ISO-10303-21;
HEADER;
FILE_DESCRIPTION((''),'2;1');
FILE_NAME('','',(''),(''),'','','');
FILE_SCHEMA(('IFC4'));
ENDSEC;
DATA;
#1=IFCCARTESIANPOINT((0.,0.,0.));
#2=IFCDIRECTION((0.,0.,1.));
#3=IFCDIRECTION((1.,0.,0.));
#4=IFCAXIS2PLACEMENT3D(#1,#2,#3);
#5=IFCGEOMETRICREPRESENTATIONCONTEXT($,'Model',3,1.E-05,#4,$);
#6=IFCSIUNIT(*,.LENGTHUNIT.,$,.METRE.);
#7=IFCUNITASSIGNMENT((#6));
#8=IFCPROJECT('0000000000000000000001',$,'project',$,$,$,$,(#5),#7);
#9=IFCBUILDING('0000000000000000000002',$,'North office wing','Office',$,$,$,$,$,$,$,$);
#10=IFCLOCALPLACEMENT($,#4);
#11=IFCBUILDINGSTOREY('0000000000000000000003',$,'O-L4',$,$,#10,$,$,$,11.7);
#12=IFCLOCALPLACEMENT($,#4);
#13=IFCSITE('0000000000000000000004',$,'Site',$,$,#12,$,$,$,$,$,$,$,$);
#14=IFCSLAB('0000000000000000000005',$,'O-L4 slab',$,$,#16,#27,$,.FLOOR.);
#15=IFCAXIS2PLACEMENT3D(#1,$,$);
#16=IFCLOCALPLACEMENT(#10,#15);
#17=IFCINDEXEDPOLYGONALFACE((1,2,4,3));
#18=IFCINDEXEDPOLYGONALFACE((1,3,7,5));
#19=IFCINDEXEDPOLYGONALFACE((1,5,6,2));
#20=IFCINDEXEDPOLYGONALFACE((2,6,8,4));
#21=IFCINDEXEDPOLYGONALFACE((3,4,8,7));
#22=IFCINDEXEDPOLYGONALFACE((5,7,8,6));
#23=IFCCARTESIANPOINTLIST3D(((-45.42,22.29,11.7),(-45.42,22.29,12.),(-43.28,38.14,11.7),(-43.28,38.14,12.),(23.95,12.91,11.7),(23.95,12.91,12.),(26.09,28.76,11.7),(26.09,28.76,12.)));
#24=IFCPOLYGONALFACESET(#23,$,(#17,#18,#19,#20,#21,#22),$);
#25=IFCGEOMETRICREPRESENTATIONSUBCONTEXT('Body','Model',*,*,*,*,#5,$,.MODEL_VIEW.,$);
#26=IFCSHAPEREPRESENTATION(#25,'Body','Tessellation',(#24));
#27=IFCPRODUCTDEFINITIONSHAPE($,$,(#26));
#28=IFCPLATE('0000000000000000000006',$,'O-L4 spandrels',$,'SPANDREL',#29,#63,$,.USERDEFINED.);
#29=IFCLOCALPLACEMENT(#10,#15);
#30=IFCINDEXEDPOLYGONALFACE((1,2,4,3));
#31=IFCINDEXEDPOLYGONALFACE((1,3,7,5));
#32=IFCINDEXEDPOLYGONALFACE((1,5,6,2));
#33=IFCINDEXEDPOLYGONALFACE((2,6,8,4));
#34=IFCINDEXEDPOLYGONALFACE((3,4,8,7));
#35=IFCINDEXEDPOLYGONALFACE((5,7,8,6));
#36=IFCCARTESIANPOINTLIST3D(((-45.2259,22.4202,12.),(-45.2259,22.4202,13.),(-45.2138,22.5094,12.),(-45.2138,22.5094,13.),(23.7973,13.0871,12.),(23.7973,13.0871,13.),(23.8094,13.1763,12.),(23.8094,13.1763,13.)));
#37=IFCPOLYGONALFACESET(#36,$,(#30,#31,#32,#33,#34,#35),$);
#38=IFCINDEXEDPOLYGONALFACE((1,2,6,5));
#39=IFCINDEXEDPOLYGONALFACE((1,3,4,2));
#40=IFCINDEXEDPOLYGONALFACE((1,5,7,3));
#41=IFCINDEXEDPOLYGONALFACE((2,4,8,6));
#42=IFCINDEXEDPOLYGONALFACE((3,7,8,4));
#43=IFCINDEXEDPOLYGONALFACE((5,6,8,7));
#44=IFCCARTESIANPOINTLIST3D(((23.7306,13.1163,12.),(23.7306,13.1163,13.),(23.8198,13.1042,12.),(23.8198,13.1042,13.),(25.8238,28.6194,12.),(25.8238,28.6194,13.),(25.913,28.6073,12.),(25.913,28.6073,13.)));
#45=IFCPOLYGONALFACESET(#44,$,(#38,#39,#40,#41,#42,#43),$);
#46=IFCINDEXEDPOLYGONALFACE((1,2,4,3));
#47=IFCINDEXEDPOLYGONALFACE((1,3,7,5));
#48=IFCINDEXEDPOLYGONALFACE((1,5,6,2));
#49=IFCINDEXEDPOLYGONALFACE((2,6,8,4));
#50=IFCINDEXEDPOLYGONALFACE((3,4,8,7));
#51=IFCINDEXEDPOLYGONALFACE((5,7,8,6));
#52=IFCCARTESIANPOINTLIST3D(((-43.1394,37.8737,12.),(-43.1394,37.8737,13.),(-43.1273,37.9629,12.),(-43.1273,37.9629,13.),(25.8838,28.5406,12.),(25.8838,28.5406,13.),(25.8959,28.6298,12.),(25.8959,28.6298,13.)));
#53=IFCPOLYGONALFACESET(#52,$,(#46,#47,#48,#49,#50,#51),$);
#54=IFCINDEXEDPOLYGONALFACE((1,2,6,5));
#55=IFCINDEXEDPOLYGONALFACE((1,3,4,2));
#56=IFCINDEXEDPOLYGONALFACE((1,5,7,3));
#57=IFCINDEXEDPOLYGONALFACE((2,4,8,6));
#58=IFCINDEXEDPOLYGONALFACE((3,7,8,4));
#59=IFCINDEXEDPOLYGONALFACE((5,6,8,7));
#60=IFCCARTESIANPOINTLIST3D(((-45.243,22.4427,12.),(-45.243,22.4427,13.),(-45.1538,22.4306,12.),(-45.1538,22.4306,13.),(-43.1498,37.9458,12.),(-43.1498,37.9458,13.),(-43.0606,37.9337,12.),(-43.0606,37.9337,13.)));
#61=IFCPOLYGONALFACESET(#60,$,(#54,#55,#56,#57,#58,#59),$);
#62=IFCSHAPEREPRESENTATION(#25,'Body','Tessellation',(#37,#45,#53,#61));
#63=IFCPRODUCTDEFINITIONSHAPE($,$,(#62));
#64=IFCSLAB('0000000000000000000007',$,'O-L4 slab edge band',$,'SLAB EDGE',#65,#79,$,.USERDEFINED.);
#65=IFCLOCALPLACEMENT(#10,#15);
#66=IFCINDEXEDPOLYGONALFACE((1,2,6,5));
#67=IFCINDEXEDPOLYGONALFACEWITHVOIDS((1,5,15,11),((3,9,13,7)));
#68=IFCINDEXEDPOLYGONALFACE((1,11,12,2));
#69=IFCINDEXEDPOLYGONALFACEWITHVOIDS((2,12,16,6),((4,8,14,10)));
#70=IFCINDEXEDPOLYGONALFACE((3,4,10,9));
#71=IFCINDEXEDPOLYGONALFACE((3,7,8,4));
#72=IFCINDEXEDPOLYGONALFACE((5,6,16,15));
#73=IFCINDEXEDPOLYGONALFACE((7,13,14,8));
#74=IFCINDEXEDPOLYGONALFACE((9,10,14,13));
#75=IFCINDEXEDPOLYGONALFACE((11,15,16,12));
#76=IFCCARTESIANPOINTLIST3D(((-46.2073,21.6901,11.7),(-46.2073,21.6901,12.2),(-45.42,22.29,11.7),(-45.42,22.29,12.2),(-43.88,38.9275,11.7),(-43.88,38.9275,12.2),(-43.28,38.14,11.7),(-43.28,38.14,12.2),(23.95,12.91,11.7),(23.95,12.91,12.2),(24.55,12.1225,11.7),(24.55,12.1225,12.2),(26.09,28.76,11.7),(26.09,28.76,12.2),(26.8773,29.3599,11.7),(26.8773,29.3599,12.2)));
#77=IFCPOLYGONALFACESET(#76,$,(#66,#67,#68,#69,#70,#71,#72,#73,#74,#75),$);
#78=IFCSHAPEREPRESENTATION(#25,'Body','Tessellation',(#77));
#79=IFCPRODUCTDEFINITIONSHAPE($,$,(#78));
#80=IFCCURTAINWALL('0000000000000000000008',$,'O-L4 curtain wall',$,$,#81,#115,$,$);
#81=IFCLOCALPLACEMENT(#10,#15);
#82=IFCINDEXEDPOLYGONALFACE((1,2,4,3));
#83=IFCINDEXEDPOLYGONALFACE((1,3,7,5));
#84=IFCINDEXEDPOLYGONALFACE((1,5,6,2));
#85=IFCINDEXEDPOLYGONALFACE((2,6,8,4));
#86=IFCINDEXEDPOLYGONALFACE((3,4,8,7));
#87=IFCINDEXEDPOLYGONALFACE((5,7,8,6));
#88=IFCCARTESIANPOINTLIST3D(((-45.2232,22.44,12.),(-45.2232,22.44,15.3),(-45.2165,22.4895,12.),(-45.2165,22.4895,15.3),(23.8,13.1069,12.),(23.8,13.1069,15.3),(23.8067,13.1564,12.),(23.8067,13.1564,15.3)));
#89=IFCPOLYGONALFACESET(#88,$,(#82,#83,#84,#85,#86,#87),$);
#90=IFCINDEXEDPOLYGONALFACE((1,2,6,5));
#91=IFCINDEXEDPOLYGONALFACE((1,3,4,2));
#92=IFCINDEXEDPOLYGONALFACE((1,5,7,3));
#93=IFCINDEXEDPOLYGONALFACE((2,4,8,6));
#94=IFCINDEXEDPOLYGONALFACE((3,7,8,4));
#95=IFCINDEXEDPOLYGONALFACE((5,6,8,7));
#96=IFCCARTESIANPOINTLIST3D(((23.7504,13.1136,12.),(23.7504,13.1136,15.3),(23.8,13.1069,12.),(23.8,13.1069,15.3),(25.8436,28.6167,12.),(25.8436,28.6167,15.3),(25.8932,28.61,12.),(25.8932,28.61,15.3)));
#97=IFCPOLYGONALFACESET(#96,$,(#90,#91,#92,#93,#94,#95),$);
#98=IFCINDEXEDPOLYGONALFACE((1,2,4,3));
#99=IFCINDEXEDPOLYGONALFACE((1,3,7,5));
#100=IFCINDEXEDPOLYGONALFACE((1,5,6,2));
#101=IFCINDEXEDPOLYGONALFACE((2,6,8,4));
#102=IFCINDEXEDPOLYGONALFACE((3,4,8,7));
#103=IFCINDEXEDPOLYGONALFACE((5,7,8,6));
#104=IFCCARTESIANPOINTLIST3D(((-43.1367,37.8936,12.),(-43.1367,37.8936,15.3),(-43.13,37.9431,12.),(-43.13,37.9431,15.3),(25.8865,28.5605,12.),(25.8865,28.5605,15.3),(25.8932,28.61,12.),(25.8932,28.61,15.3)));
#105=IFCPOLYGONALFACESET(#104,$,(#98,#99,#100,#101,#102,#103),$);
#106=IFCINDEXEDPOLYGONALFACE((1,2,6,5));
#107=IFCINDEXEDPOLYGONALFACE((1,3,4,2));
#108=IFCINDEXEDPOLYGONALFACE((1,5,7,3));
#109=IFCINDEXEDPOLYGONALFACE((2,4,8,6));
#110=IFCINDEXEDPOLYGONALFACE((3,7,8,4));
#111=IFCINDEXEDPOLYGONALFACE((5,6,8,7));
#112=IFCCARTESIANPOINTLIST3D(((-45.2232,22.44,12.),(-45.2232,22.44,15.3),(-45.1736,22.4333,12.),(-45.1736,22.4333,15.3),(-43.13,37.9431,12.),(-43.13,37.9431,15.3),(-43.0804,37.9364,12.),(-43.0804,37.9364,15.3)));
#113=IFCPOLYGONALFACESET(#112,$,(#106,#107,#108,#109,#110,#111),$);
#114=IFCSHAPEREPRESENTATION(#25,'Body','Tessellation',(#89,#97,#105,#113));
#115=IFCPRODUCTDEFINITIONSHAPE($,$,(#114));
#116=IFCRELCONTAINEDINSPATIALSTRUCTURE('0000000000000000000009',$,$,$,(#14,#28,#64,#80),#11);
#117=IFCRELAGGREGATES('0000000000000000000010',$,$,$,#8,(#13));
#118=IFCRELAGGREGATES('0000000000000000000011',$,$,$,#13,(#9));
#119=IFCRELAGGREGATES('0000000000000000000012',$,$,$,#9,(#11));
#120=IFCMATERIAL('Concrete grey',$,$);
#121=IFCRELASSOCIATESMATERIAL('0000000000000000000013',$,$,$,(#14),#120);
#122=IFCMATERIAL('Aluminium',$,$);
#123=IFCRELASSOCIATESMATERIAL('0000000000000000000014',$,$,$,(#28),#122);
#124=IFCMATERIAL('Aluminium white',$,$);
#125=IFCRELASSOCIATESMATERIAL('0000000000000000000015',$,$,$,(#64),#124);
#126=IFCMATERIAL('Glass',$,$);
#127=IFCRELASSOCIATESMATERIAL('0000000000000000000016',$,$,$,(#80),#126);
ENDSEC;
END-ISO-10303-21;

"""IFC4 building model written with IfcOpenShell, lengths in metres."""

from ifc_helpers import new_model, si_unit, frame, origin_with_axes, place, context, subcontext, project, spatial, polyline, outline, extrude, material, element, save


model = new_model("IFC4")

# Units and contexts
model_context = context("Model", 3, precision=1e-05, world=origin_with_axes())
body_context = subcontext(model_context, "Body", "Model", "MODEL_VIEW")
ifc_project = project(units=[si_unit("LENGTHUNIT", "METRE")], contexts=[model_context])

# Site, building, storey
site_placement = place(None, origin_with_axes())
site = spatial("IfcSite", under=ifc_project, at=site_placement, Name="Site")
building = spatial("IfcBuilding", under=site, Name="North office wing", Description="Office")
storey_placement = place(None, origin_with_axes())
storey = spatial("IfcBuildingStorey", under=building, at=storey_placement, Name="O-L4", Elevation=11.7)

# Shared definitions
ifc_material_1 = material(Name="Aluminium")

# Slab
ifc_material_2 = material(Name="Concrete grey")
slab_1_placement = place(storey_placement, origin_with_axes())
element("IfcSlab", 1, at=slab_1_placement, inside=storey, material=ifc_material_2, Name="O-L4 slab", PredefinedType="FLOOR", context=body_context, shape_type="SweptSolid", body=[
    extrude(outline(polyline([(-45.42, 22.29), (23.95, 12.91), (26.09, 28.76), (-43.28, 38.14), (-45.42, 22.29)])), frame((0.0, 0.0, 11.7), z_axis=(0.0, 0.0, 1.0), x_axis=(1.0, 0.0, 0.0)), (0.0, 0.0, 1.0), 0.3),
])

# Plate
plate_placement = place(storey_placement, origin_with_axes())
element("IfcPlate", 2, at=plate_placement, inside=storey, material=ifc_material_1, Name="O-L4 spandrels", ObjectType="SPANDREL", PredefinedType="USERDEFINED", context=body_context, shape_type="SweptSolid", body=[
    extrude(outline(polyline([(-45.2259, 22.4202), (23.7973, 13.0871), (23.8094, 13.1763), (-45.2138, 22.5094), (-45.2259, 22.4202)])), frame((0.0, 0.0, 12.0), z_axis=(0.0, 0.0, 1.0), x_axis=(1.0, 0.0, 0.0)), (0.0, 0.0, 1.0), 1.0),
    extrude(outline(polyline([(23.8198, 13.1042), (25.913, 28.6073), (25.8238, 28.6194), (23.7306, 13.1163), (23.8198, 13.1042)])), frame((0.0, 0.0, 12.0), z_axis=(0.0, 0.0, 1.0), x_axis=(1.0, 0.0, 0.0)), (0.0, 0.0, 1.0), 1.0),
    extrude(outline(polyline([(25.8959, 28.6298), (-43.1273, 37.9629), (-43.1394, 37.8737), (25.8838, 28.5406), (25.8959, 28.6298)])), frame((0.0, 0.0, 12.0), z_axis=(0.0, 0.0, 1.0), x_axis=(1.0, 0.0, 0.0)), (0.0, 0.0, 1.0), 1.0),
    extrude(outline(polyline([(-43.1498, 37.9458), (-45.243, 22.4427), (-45.1538, 22.4306), (-43.0606, 37.9337), (-43.1498, 37.9458)])), frame((0.0, 0.0, 12.0), z_axis=(0.0, 0.0, 1.0), x_axis=(1.0, 0.0, 0.0)), (0.0, 0.0, 1.0), 1.0),
])

# Slab
ifc_material_3 = material(Name="Aluminium white")
slab_2_placement = place(storey_placement, origin_with_axes())
element("IfcSlab", 3, at=slab_2_placement, inside=storey, material=ifc_material_3, Name="O-L4 slab edge band", ObjectType="SLAB EDGE", PredefinedType="USERDEFINED", context=body_context, shape_type="SweptSolid", body=[
    extrude(outline(polyline([(-46.2073, 21.6901), (24.55, 12.1225), (26.8773, 29.3599), (-43.88, 38.9275), (-46.2073, 21.6901)]), holes=[polyline([(-45.42, 22.29), (23.95, 12.91), (26.09, 28.76), (-43.28, 38.14), (-45.42, 22.29)])]), frame((0.0, 0.0, 11.7), z_axis=(0.0, 0.0, 1.0), x_axis=(1.0, 0.0, 0.0)), (0.0, 0.0, 1.0), 0.5),
])

# Curtain wall
ifc_material_4 = material(Name="Glass")
curtain_wall_placement = place(storey_placement, origin_with_axes())
element("IfcCurtainWall", 4, at=curtain_wall_placement, inside=storey, material=ifc_material_4, Name="O-L4 curtain wall", context=body_context, shape_type="SweptSolid", body=[
    extrude(outline(polyline([(-45.2232, 22.44), (23.8, 13.1069), (23.8067, 13.1564), (-45.2165, 22.4895), (-45.2232, 22.44)])), frame((0.0, 0.0, 12.0), z_axis=(0.0, 0.0, 1.0), x_axis=(1.0, 0.0, 0.0)), (0.0, 0.0, 1.0), 3.3),
    extrude(outline(polyline([(23.8, 13.1069), (25.8932, 28.61), (25.8436, 28.6167), (23.7504, 13.1136), (23.8, 13.1069)])), frame((0.0, 0.0, 12.0), z_axis=(0.0, 0.0, 1.0), x_axis=(1.0, 0.0, 0.0)), (0.0, 0.0, 1.0), 3.3),
    extrude(outline(polyline([(25.8932, 28.61), (-43.13, 37.9431), (-43.1367, 37.8936), (25.8865, 28.5605), (25.8932, 28.61)])), frame((0.0, 0.0, 12.0), z_axis=(0.0, 0.0, 1.0), x_axis=(1.0, 0.0, 0.0)), (0.0, 0.0, 1.0), 3.3),
    extrude(outline(polyline([(-43.13, 37.9431), (-45.2232, 22.44), (-45.1736, 22.4333), (-43.0804, 37.9364), (-43.13, 37.9431)])), frame((0.0, 0.0, 12.0), z_axis=(0.0, 0.0, 1.0), x_axis=(1.0, 0.0, 0.0)), (0.0, 0.0, 1.0), 3.3),
])

save(model, "model.ifc")
